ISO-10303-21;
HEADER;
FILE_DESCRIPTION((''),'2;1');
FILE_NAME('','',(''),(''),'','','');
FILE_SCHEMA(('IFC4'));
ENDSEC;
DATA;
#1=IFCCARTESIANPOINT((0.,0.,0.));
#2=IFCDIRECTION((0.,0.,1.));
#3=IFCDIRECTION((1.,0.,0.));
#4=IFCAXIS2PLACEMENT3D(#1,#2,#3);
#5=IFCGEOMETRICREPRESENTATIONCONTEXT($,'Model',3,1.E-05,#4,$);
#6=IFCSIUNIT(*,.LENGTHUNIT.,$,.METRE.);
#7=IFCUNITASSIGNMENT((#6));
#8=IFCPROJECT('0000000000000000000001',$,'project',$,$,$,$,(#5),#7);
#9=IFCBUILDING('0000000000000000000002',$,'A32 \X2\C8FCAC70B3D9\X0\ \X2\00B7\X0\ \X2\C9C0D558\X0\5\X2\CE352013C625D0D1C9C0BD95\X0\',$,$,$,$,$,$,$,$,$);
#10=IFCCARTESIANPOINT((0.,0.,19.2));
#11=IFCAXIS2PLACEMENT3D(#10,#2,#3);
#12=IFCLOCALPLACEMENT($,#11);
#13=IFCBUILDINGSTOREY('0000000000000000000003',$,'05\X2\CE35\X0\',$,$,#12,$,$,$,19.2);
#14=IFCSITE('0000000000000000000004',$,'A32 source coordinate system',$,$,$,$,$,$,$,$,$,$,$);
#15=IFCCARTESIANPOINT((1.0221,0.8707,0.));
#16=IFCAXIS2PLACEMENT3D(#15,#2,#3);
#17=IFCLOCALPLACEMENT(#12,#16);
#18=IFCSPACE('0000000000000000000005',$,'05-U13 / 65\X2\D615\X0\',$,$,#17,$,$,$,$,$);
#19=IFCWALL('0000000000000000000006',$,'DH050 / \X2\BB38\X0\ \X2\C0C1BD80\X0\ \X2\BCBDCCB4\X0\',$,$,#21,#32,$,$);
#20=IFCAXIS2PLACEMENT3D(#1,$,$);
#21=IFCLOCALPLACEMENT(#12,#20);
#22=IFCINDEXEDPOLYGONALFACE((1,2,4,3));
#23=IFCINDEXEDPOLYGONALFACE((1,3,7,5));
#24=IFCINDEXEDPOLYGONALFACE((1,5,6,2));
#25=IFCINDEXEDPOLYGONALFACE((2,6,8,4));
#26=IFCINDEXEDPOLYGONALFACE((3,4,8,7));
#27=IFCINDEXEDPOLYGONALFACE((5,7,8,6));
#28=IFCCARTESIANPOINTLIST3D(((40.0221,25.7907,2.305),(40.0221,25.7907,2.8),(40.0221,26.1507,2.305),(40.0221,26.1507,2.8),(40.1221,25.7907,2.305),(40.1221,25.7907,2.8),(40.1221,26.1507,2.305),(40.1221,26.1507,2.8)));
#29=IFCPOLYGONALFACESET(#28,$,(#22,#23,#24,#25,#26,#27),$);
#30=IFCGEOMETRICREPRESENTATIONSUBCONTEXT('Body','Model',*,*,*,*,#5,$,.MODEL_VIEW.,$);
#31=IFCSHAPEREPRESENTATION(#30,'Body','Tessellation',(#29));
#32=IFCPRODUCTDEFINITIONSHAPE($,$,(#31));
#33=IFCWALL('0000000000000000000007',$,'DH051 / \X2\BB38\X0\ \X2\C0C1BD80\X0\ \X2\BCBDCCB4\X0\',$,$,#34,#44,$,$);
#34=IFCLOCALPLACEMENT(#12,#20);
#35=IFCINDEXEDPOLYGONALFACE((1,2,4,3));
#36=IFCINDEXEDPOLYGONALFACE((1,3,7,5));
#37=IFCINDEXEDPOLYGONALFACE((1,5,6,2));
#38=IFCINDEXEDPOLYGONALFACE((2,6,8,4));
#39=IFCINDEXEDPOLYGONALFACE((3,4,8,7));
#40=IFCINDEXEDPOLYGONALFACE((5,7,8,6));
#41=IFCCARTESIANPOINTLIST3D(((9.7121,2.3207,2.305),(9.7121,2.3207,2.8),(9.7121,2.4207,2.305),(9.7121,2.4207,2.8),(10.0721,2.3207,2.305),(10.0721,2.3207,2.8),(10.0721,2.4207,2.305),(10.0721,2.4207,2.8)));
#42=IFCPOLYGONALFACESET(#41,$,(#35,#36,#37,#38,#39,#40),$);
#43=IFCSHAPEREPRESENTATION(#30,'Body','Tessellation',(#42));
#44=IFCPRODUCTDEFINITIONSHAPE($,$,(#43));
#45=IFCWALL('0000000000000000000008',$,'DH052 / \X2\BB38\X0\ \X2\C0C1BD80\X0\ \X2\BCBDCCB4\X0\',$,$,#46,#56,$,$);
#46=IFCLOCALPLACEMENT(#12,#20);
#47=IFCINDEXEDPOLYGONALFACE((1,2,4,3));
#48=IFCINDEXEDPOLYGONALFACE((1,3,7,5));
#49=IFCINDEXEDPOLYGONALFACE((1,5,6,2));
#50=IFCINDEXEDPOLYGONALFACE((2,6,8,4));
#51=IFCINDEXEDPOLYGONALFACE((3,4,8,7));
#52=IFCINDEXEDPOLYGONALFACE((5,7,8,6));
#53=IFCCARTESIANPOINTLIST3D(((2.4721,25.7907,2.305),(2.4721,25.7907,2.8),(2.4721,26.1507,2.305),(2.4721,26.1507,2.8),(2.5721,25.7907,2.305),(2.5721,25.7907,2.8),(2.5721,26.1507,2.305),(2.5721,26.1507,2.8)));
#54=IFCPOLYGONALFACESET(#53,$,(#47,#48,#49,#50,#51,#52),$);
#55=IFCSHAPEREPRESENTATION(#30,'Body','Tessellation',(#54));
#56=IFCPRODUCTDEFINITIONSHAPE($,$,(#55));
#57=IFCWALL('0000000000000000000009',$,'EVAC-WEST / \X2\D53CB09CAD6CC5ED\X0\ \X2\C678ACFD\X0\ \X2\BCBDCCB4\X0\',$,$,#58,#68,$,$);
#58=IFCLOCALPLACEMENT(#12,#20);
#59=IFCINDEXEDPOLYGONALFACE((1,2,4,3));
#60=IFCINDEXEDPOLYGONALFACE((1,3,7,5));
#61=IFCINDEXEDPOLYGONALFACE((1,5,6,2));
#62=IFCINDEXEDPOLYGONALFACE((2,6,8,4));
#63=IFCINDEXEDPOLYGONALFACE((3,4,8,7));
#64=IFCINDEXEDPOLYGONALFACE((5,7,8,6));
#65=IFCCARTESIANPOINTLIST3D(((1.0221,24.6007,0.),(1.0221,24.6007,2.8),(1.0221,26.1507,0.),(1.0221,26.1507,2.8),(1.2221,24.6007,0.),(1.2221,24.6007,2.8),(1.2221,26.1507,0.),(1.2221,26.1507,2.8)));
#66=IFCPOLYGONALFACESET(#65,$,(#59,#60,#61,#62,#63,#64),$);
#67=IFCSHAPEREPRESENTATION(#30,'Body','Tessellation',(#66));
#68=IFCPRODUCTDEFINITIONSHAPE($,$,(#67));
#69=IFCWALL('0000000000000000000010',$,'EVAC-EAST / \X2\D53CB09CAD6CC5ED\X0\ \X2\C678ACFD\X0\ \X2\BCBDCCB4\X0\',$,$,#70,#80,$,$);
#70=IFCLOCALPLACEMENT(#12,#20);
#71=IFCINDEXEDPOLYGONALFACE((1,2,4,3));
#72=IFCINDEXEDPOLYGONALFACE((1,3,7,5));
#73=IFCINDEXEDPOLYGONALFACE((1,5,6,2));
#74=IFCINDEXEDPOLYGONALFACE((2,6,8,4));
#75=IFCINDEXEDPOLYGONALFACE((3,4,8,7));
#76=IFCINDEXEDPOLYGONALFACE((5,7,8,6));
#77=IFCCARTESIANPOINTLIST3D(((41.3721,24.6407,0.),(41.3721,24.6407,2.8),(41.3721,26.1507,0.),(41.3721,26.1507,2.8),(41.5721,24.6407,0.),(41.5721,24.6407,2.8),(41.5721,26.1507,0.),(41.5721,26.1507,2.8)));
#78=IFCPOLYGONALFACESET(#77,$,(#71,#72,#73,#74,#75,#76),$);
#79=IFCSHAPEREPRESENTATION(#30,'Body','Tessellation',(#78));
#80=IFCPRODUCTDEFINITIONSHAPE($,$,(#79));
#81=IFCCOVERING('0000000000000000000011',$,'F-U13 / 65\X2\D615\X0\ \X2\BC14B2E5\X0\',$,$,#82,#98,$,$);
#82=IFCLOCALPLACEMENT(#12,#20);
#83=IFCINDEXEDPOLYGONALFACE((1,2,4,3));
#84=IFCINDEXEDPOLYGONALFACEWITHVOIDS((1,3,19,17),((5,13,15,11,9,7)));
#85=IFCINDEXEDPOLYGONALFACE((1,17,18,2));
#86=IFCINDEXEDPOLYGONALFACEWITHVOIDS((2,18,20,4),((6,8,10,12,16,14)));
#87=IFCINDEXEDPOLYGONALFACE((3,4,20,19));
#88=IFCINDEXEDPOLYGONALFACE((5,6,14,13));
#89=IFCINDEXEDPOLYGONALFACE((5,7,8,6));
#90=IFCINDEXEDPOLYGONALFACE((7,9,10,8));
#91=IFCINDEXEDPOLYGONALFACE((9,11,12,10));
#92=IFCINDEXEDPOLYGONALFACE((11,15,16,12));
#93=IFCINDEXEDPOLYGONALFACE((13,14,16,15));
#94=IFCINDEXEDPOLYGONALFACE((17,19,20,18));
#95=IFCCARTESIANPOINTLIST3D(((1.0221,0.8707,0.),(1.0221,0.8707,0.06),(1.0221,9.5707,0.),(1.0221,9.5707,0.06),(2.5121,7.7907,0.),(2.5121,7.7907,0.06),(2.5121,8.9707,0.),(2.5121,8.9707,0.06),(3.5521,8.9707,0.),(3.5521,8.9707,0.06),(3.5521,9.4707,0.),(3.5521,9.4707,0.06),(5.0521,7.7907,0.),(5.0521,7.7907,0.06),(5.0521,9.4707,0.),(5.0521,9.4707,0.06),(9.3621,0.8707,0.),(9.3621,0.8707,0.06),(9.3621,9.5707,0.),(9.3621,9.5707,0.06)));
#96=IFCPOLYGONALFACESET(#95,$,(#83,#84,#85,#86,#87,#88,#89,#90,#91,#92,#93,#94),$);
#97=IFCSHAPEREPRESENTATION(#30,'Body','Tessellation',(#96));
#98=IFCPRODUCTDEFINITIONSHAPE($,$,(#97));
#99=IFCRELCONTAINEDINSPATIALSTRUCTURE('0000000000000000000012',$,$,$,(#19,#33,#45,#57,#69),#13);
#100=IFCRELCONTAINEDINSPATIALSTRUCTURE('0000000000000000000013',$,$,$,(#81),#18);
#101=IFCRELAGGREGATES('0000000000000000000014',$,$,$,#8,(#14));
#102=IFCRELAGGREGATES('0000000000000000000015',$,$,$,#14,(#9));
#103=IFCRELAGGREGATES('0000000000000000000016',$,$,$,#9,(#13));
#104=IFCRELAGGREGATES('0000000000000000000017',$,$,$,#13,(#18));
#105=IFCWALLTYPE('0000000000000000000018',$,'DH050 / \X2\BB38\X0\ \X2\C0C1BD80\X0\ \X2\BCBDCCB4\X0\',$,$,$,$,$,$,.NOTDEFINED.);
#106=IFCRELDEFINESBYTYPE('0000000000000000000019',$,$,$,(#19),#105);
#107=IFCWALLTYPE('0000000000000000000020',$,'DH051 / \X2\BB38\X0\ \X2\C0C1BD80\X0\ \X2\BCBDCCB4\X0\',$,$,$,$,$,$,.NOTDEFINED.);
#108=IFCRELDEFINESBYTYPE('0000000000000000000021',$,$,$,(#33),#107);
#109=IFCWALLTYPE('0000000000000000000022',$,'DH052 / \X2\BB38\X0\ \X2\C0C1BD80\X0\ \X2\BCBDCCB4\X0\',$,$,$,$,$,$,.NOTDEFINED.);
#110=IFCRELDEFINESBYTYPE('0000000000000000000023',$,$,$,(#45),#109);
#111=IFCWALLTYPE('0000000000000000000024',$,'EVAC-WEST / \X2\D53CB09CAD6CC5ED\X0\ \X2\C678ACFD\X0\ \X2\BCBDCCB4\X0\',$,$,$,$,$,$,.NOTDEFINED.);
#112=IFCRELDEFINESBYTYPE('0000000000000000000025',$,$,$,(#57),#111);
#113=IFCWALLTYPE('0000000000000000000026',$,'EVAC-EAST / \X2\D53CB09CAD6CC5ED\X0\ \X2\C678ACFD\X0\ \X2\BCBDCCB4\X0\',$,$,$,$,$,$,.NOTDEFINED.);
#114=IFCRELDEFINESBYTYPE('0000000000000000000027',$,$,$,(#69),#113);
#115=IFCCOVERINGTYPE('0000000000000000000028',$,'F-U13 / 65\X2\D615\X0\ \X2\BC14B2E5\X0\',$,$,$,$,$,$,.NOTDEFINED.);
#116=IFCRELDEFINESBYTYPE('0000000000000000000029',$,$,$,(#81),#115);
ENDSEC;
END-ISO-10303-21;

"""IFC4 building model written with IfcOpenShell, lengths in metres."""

from ifc_helpers import new_model, si_unit, frame, origin, origin_with_axes, place, context, subcontext, project, spatial, polyline, outline, extrude, source, transform, mapped, type_object, type_shapes, element, save


model = new_model("IFC4")

# Units and contexts
model_context = context("Model", 3, precision=1e-05, world=origin_with_axes())
body_context = subcontext(model_context, "Body", "Model", "MODEL_VIEW")
ifc_project = project(units=[si_unit("LENGTHUNIT", "METRE")], contexts=[model_context])

# Site, building, storey
site = spatial("IfcSite", under=ifc_project, Name="A32 source coordinate system")
building = spatial("IfcBuilding", under=site, Name="A32 주거동 · 지하5층–옥탑지붕")
storey_placement = place(None, frame((0.0, 0.0, 19.2), z_axis=(0.0, 0.0, 1.0), x_axis=(1.0, 0.0, 0.0)))
storey = spatial("IfcBuildingStorey", under=building, at=storey_placement, Name="05층", Elevation=19.2)

# Walls
wall_type_1 = type_object("IfcWallType", Name="DH050 / 문 상부 벽체", PredefinedType="NOTDEFINED")
shared_shape_1 = source(origin(), body_context, "Body", "SweptSolid", [
    extrude(outline(polyline([(40.0221, 25.7907), (40.0221, 26.1507), (40.1221, 26.1507), (40.1221, 25.7907), (40.0221, 25.7907)])), frame((0.0, 0.0, 2.305)), (0.0, 0.0, 1.0), 0.495),
])
type_shapes(wall_type_1, [shared_shape_1])
wall_1_placement = place(storey_placement, origin_with_axes())
element("IfcWall", 1, at=wall_1_placement, inside=storey, type_object=wall_type_1, Name="DH050 / 문 상부 벽체", context=body_context, shape_type="MappedRepresentation", body=[
    mapped(shared_shape_1, transform((0.0, 0.0, 0.0), scale=1.0)),
])
wall_type_2 = type_object("IfcWallType", Name="DH051 / 문 상부 벽체", PredefinedType="NOTDEFINED")
shared_shape_2 = source(origin(), body_context, "Body", "SweptSolid", [
    extrude(outline(polyline([(10.0721, 2.3207), (9.7121, 2.3207), (9.7121, 2.4207), (10.0721, 2.4207), (10.0721, 2.3207)])), frame((0.0, 0.0, 2.305)), (0.0, 0.0, 1.0), 0.495),
])
type_shapes(wall_type_2, [shared_shape_2])
wall_2_placement = place(storey_placement, origin_with_axes())
element("IfcWall", 2, at=wall_2_placement, inside=storey, type_object=wall_type_2, Name="DH051 / 문 상부 벽체", context=body_context, shape_type="MappedRepresentation", body=[
    mapped(shared_shape_2, transform((0.0, 0.0, 0.0), scale=1.0)),
])
wall_type_3 = type_object("IfcWallType", Name="DH052 / 문 상부 벽체", PredefinedType="NOTDEFINED")
shared_shape_3 = source(origin(), body_context, "Body", "SweptSolid", [
    extrude(outline(polyline([(2.5721, 25.7907), (2.4721, 25.7907), (2.4721, 26.1507), (2.5721, 26.1507), (2.5721, 25.7907)])), frame((0.0, 0.0, 2.305)), (0.0, 0.0, 1.0), 0.495),
])
type_shapes(wall_type_3, [shared_shape_3])
wall_3_placement = place(storey_placement, origin_with_axes())
element("IfcWall", 3, at=wall_3_placement, inside=storey, type_object=wall_type_3, Name="DH052 / 문 상부 벽체", context=body_context, shape_type="MappedRepresentation", body=[
    mapped(shared_shape_3, transform((0.0, 0.0, 0.0), scale=1.0)),
])
wall_type_4 = type_object("IfcWallType", Name="EVAC-WEST / 피난구역 외곽 벽체", PredefinedType="NOTDEFINED")
shared_shape_4 = source(origin(), body_context, "Body", "SweptSolid", [
    extrude(outline(polyline([(1.2221, 24.6007), (1.0221, 24.6007), (1.0221, 26.1507), (1.2221, 26.1507), (1.2221, 24.6007)])), origin(), (0.0, 0.0, 1.0), 2.8),
])
type_shapes(wall_type_4, [shared_shape_4])
wall_4_placement = place(storey_placement, origin_with_axes())
element("IfcWall", 4, at=wall_4_placement, inside=storey, type_object=wall_type_4, Name="EVAC-WEST / 피난구역 외곽 벽체", context=body_context, shape_type="MappedRepresentation", body=[
    mapped(shared_shape_4, transform((0.0, 0.0, 0.0), scale=1.0)),
])
wall_type_5 = type_object("IfcWallType", Name="EVAC-EAST / 피난구역 외곽 벽체", PredefinedType="NOTDEFINED")
shared_shape_5 = source(origin(), body_context, "Body", "SweptSolid", [
    extrude(outline(polyline([(41.5721, 26.1507), (41.5721, 24.6407), (41.3721, 24.6407), (41.3721, 26.1507), (41.5721, 26.1507)])), origin(), (0.0, 0.0, 1.0), 2.8),
])
type_shapes(wall_type_5, [shared_shape_5])
wall_5_placement = place(storey_placement, origin_with_axes())
element("IfcWall", 5, at=wall_5_placement, inside=storey, type_object=wall_type_5, Name="EVAC-EAST / 피난구역 외곽 벽체", context=body_context, shape_type="MappedRepresentation", body=[
    mapped(shared_shape_5, transform((0.0, 0.0, 0.0), scale=1.0)),
])

# Shared definitions
space_placement = place(storey_placement, frame((1.0221, 0.8707, 0.0), z_axis=(0.0, 0.0, 1.0), x_axis=(1.0, 0.0, 0.0)))
space = spatial("IfcSpace", under=storey, at=space_placement, Name="05-U13 / 65형")

# Covering
covering_type_1 = type_object("IfcCoveringType", Name="F-U13 / 65형 바닥", PredefinedType="NOTDEFINED")
shared_shape_6 = source(origin(), body_context, "Body", "SweptSolid", [
    extrude(outline(polyline([(0.0, 0.0), (0.0, 8.7), (8.34, 8.7), (8.34, 0.0), (0.0, 0.0)]), holes=[polyline([(2.53, 8.1), (1.49, 8.1), (1.49, 6.92), (4.03, 6.92), (4.03, 8.6), (2.53, 8.6), (2.53, 8.1)])]), origin(), (0.0, 0.0, 1.0), 0.06),
])
type_shapes(covering_type_1, [shared_shape_6])
covering_1_placement = place(space_placement, origin_with_axes())
element("IfcCovering", 6, at=covering_1_placement, inside=space, type_object=covering_type_1, Name="F-U13 / 65형 바닥", context=body_context, shape_type="MappedRepresentation", body=[
    mapped(shared_shape_6, transform((0.0, 0.0, 0.0), scale=1.0)),
])

save(model, "model.ifc")
